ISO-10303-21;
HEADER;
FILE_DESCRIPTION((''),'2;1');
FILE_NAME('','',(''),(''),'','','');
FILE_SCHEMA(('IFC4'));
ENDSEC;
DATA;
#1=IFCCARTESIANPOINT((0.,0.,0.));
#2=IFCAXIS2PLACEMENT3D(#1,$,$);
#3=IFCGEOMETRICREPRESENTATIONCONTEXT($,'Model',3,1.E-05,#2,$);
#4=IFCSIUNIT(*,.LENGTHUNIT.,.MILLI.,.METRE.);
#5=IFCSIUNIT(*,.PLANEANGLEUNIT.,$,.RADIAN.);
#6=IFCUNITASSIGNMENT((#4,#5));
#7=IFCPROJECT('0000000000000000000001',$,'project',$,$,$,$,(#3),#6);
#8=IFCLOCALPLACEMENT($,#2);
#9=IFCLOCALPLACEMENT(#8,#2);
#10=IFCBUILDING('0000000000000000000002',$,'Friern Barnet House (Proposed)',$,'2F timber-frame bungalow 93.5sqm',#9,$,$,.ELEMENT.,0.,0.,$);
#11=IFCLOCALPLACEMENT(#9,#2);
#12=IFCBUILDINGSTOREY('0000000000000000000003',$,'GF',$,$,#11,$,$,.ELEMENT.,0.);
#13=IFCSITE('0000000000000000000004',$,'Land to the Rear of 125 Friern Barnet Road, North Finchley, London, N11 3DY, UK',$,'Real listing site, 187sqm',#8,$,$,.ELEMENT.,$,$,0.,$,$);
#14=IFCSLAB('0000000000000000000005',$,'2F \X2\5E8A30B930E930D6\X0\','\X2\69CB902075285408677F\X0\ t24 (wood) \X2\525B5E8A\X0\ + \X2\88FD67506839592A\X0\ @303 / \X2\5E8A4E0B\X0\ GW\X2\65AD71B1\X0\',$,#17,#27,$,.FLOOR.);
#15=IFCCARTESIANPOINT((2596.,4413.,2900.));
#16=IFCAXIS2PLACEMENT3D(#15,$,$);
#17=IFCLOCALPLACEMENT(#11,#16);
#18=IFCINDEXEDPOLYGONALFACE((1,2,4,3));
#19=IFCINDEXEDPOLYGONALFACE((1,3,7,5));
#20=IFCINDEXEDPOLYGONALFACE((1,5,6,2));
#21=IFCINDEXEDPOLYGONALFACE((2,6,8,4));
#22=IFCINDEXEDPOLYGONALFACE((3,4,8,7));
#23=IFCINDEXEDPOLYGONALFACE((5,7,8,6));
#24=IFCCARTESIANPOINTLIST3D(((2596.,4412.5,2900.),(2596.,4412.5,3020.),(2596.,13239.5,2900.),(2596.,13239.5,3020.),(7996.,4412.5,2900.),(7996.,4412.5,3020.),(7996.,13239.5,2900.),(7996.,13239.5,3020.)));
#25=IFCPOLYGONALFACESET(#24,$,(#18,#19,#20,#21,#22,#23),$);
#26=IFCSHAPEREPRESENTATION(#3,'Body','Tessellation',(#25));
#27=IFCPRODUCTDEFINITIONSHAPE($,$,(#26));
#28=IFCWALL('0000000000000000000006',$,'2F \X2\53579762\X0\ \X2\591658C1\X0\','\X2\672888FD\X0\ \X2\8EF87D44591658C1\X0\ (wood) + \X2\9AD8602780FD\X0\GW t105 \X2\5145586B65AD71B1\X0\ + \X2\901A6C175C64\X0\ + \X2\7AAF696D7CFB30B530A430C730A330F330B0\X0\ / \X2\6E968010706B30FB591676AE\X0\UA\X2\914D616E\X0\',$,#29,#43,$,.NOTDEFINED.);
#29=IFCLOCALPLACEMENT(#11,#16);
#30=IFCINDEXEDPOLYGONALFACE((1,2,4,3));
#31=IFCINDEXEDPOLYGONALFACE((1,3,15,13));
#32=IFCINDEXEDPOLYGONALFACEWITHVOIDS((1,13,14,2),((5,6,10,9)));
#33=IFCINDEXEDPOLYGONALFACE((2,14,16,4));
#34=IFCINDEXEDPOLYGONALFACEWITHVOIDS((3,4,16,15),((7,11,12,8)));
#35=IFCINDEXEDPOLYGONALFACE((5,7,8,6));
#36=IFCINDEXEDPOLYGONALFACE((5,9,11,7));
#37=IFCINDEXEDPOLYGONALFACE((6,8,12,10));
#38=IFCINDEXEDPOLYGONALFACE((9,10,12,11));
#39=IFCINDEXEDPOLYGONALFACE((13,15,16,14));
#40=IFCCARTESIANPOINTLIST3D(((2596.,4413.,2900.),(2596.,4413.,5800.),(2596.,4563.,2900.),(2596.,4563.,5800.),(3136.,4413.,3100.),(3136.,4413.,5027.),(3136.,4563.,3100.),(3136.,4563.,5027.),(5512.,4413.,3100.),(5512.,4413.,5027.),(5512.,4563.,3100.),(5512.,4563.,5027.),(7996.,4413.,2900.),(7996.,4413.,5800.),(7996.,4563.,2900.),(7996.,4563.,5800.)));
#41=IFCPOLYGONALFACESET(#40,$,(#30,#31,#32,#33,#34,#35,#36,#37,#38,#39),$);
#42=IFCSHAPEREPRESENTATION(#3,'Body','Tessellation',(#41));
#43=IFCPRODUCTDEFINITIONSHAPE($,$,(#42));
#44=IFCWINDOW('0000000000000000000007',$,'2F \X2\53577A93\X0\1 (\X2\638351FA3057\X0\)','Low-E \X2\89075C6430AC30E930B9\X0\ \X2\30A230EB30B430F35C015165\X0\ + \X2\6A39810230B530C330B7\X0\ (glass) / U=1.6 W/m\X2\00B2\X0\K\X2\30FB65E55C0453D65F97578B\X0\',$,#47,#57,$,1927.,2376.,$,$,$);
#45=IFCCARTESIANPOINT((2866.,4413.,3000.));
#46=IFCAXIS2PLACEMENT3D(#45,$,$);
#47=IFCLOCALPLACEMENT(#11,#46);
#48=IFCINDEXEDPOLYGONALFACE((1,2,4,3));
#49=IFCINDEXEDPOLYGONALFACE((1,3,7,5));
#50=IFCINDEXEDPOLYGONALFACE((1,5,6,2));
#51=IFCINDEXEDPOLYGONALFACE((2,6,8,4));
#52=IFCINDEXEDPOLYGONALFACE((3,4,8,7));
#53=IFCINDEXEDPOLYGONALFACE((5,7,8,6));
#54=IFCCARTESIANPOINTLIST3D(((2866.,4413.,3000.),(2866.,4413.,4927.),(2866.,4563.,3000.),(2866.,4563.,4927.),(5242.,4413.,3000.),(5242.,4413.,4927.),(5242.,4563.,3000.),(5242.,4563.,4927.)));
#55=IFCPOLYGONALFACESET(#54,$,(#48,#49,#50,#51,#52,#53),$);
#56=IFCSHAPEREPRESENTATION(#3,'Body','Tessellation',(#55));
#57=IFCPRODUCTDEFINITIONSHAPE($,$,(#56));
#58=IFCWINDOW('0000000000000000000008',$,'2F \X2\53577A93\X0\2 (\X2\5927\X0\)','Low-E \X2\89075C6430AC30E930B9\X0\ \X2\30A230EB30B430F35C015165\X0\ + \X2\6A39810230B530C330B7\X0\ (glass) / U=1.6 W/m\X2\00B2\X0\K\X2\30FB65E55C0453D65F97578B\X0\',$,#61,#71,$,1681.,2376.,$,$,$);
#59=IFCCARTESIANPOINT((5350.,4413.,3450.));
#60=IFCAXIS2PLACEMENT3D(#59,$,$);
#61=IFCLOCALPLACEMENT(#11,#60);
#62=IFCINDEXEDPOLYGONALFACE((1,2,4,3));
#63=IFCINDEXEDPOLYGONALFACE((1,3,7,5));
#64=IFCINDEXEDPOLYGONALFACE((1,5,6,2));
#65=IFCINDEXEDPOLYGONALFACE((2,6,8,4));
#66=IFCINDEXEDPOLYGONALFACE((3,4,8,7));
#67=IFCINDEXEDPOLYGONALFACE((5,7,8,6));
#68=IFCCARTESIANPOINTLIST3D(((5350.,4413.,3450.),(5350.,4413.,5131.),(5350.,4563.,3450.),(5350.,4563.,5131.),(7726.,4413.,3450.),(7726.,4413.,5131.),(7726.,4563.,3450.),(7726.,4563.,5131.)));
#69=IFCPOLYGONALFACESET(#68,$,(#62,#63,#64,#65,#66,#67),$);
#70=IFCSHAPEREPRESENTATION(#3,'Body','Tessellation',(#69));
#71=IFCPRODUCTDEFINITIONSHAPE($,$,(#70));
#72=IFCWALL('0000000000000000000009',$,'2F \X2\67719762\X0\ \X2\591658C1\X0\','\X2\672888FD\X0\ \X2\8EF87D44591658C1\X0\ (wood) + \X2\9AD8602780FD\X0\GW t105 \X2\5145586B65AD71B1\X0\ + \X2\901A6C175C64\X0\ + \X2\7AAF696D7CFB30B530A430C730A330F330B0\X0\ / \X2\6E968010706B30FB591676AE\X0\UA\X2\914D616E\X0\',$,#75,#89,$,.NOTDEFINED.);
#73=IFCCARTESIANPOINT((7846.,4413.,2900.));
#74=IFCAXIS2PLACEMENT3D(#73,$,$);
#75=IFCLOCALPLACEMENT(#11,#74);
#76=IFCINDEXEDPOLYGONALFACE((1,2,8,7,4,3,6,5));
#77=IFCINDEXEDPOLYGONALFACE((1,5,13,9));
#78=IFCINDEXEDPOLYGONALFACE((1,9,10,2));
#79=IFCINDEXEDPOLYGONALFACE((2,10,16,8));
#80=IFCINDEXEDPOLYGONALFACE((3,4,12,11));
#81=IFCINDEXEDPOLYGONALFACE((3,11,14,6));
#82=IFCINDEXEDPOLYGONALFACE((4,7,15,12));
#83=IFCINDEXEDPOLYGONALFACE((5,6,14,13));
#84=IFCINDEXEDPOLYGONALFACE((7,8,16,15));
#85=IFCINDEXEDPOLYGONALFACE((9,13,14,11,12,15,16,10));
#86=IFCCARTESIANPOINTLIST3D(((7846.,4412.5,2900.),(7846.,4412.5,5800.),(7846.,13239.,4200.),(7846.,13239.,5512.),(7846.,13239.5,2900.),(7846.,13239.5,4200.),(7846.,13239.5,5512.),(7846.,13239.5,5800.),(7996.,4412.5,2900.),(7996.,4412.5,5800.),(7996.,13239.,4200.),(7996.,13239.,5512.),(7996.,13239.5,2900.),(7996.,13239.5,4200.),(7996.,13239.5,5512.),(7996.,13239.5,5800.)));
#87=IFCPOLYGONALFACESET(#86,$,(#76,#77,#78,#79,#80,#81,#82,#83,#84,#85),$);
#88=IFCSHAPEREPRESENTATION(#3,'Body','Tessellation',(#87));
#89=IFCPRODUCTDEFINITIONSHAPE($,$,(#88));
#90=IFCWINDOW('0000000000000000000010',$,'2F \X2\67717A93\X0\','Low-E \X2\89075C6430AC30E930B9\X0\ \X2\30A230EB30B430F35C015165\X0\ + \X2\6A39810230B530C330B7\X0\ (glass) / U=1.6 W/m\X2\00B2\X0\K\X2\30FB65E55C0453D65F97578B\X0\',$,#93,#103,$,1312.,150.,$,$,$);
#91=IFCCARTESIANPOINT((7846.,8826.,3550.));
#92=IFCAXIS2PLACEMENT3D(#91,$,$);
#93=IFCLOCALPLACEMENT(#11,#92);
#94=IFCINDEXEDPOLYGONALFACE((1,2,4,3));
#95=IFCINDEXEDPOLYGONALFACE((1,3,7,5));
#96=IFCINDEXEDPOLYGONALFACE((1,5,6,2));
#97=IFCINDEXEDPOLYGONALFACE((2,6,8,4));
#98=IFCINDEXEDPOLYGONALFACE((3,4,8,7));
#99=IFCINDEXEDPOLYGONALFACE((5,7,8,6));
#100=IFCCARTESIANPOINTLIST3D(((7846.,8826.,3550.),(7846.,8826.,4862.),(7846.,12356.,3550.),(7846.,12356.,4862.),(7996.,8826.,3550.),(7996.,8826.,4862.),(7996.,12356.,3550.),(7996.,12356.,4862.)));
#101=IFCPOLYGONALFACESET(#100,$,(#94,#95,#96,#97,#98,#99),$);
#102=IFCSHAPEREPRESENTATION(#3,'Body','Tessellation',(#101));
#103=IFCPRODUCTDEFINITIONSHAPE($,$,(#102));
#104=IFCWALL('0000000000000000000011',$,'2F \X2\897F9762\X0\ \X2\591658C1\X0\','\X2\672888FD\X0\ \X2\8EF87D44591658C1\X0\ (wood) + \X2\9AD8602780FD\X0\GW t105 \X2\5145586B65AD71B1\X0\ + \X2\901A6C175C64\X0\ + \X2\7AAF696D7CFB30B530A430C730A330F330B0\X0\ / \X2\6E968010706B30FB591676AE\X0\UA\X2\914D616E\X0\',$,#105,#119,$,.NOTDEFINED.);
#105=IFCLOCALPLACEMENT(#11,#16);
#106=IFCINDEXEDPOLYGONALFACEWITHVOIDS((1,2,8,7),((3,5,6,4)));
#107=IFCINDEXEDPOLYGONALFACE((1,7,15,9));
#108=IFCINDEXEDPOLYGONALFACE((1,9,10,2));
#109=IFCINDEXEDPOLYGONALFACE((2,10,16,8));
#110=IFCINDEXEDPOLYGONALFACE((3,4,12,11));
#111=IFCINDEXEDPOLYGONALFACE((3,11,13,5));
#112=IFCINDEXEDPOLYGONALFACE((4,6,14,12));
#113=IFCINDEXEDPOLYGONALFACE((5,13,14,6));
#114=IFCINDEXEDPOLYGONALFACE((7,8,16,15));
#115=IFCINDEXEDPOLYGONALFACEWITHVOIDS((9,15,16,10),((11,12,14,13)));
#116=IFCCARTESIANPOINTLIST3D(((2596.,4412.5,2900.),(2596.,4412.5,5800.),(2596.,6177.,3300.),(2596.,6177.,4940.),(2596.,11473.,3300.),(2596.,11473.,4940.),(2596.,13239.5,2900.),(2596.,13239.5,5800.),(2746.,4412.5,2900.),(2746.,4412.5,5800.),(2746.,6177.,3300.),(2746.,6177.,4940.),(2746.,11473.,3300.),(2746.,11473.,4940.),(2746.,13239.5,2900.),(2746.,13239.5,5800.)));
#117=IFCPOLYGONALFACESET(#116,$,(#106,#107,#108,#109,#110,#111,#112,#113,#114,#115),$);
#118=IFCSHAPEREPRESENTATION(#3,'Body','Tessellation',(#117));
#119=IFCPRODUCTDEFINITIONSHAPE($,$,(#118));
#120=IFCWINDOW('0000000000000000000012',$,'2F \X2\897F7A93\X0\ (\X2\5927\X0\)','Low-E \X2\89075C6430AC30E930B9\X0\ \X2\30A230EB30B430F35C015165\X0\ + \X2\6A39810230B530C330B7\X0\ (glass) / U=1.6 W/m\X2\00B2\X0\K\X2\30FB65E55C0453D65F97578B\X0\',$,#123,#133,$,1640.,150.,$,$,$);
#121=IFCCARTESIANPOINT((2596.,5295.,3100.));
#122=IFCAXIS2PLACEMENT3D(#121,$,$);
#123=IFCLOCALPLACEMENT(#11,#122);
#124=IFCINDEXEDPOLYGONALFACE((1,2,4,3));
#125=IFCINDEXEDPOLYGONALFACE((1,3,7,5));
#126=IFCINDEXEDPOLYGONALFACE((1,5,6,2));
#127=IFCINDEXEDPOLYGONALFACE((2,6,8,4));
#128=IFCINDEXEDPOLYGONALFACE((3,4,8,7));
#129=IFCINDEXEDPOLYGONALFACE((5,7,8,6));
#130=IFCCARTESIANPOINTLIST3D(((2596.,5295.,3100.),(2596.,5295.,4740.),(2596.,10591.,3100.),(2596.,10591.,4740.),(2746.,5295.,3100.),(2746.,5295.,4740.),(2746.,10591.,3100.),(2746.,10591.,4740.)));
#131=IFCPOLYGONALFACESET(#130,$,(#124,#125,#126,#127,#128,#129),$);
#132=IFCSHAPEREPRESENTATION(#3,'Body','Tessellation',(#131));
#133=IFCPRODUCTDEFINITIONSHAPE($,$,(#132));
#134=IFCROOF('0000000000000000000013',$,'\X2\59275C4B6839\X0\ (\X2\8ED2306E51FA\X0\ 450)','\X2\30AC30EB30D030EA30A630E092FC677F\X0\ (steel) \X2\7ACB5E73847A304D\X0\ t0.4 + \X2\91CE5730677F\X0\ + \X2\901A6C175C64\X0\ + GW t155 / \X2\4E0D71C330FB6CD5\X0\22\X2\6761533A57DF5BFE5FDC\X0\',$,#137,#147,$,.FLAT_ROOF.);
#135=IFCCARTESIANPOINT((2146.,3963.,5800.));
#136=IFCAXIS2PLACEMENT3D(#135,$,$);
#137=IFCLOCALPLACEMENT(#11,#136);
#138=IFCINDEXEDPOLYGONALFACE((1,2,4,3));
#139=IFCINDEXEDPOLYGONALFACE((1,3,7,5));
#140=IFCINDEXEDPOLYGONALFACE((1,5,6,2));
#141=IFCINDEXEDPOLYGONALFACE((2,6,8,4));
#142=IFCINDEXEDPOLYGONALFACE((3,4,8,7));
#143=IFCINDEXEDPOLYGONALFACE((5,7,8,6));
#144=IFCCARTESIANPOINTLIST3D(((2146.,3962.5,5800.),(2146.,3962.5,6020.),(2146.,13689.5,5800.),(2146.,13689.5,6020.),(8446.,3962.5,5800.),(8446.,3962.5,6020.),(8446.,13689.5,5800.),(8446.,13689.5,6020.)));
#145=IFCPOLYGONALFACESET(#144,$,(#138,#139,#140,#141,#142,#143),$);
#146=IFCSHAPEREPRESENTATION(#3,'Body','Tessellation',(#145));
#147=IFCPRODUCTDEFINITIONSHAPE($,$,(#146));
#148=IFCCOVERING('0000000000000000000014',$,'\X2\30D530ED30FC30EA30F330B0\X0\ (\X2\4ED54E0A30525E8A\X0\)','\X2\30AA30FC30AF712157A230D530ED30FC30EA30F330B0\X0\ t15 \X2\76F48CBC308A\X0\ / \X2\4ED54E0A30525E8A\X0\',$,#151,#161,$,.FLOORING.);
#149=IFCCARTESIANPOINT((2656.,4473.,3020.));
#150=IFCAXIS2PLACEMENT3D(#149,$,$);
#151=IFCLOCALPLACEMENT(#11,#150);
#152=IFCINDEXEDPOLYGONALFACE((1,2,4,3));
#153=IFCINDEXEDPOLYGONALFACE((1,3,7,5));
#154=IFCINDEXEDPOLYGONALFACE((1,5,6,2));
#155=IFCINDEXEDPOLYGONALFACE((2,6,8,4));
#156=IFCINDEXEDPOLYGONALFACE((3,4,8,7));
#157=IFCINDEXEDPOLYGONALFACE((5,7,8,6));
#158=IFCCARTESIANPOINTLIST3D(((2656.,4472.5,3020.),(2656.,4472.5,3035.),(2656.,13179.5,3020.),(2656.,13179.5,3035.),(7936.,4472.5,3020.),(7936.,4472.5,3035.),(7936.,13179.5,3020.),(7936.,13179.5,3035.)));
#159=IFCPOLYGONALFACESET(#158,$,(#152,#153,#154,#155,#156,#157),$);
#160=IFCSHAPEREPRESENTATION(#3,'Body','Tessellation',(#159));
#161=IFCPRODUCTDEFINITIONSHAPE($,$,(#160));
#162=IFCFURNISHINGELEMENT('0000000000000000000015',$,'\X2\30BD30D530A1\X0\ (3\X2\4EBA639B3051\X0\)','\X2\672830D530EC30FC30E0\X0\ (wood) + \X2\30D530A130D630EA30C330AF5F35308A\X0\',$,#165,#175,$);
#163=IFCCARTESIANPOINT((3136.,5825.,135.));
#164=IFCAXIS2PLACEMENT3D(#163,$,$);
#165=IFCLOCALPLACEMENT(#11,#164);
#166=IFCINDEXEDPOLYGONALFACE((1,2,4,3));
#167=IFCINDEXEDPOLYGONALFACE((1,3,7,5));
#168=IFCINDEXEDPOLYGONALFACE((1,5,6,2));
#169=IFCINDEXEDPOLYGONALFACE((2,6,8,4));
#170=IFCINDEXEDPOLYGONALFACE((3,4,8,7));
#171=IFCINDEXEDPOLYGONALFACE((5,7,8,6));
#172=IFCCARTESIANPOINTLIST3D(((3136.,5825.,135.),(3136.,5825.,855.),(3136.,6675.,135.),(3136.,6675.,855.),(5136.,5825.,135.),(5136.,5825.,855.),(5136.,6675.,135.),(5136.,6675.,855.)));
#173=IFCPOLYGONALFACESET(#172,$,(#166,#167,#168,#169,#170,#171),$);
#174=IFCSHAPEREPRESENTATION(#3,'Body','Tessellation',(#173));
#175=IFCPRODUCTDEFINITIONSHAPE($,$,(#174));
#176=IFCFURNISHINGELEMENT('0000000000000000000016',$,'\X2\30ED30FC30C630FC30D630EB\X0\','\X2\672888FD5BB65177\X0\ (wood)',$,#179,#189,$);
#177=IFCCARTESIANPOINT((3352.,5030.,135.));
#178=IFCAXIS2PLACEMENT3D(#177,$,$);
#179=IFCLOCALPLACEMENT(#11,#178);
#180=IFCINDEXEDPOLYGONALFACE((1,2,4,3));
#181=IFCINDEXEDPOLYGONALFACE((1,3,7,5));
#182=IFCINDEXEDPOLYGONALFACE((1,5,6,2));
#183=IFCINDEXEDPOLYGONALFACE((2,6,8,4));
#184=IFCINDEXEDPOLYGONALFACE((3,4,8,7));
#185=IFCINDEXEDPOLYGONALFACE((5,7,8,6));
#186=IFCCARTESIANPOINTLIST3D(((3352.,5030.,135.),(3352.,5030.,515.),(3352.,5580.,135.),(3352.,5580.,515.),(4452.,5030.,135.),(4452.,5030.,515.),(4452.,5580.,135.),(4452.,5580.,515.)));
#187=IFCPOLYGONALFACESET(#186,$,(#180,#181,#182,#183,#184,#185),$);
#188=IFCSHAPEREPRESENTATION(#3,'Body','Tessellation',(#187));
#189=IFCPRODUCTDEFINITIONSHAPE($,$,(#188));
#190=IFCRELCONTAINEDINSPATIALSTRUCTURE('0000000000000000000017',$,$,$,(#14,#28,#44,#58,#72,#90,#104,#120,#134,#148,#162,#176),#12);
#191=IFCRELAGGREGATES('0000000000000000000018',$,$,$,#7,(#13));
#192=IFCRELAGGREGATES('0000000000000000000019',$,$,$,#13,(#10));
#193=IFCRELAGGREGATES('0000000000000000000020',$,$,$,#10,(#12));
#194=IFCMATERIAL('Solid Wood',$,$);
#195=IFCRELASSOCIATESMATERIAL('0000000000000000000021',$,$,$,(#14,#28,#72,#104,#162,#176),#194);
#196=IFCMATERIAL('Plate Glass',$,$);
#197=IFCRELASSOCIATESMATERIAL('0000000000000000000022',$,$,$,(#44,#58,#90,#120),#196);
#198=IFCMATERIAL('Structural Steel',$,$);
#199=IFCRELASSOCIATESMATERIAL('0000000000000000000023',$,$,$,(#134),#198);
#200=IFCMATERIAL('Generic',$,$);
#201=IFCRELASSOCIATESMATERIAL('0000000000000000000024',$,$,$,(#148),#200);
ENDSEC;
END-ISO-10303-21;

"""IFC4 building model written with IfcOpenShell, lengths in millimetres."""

from ifc_helpers import new_model, si_unit, frame, frame_2d, origin, place, context, project, spatial, rectangle, extrude, material, element, fill, save


model = new_model("IFC4")

# Units and contexts
model_context = context("Model", 3, precision=1e-05, world=origin())
ifc_project = project(units=[si_unit("LENGTHUNIT", "METRE", prefix="MILLI"), si_unit("PLANEANGLEUNIT", "RADIAN")], contexts=[model_context])

# Site, building, storey
site_placement = place(None, origin())
site = spatial("IfcSite", under=ifc_project, at=site_placement, Name="Land to the Rear of 125 Friern Barnet Road, North Finchley, London, N11 3DY, UK", ObjectType="Real listing site, 187sqm", CompositionType="ELEMENT", RefElevation=0.0)
building_placement = place(site_placement, origin())
building = spatial("IfcBuilding", under=site, at=building_placement, Name="Friern Barnet House (Proposed)", ObjectType="2F timber-frame bungalow 93.5sqm", CompositionType="ELEMENT", ElevationOfRefHeight=0.0, ElevationOfTerrain=0.0)
storey_placement = place(building_placement, origin())
storey = spatial("IfcBuildingStorey", under=building, at=storey_placement, Name="GF", CompositionType="ELEMENT", Elevation=0.0)

# Slab
ifc_material_1 = material(Name="Solid Wood")
slab_placement = place(storey_placement, frame((2596.0, 4413.0, 2900.0)))
element("IfcSlab", 1, at=slab_placement, inside=storey, material=ifc_material_1, Name="2F 床スラブ", Description="構造用合板 t24 (wood) 剛床 + 製材根太 @303 / 床下 GW断熱", PredefinedType="FLOOR", context=model_context, shape_type="SweptSolid", body=[
    extrude(rectangle(XDim=5400.0, YDim=8827.0, at=frame_2d((2700.0, 4413.0))), frame((2596.0, 4413.0, 2900.0)), (0.0, 0.0, 1.0), 120.0),
])

# Wall, openings, windows
wall_1_placement = place(storey_placement, frame((2596.0, 4413.0, 2900.0)))
wall_1 = element("IfcWall", 2, at=wall_1_placement, inside=storey, material=ifc_material_1, Name="2F 南面 外壁", Description="木製 軸組外壁 (wood) + 高性能GW t105 充填断熱 + 通気層 + 窯業系サイディング / 準耐火・外皮UA配慮", PredefinedType="NOTDEFINED", context=model_context, shape_type="SweptSolid", body=[
    extrude(rectangle(XDim=5400.0, YDim=150.0, at=frame_2d((2700.0, 75.0))), frame((2596.0, 4413.0, 2900.0)), (0.0, 0.0, 1.0), 2900.0),
])
opening_1_placement = place(storey_placement, frame((2866.0, 4413.0, 3000.0)))
opening_1 = element("IfcOpeningElement", 3, at=opening_1_placement, cuts=wall_1, PredefinedType="NOTDEFINED", context=model_context, shape_type="SweptSolid", body=[
    extrude(rectangle(XDim=2376.0, YDim=150.0, at=frame_2d((1188.0, 75.0))), frame((2866.0, 4413.0, 3000.0)), (0.0, 0.0, 1.0), 1927.0),
])
opening_2_placement = place(storey_placement, frame((5350.0, 4413.0, 3450.0)))
opening_2 = element("IfcOpeningElement", 4, at=opening_2_placement, cuts=wall_1, PredefinedType="NOTDEFINED", context=model_context, shape_type="SweptSolid", body=[
    extrude(rectangle(XDim=2376.0, YDim=150.0, at=frame_2d((1188.0, 75.0))), frame((5350.0, 4413.0, 3450.0)), (0.0, 0.0, 1.0), 1681.0),
])
ifc_material_2 = material(Name="Plate Glass")
window_1_placement = place(storey_placement, frame((2866.0, 4413.0, 3000.0)))
window_1 = element("IfcWindow", 5, at=window_1_placement, inside=storey, material=ifc_material_2, Name="2F 南窓1 (掃出し)", Description="Low-E 複層ガラス アルゴン封入 + 樹脂サッシ (glass) / U=1.6 W/m²K・日射取得型", OverallHeight=1927.0, OverallWidth=2376.0, context=model_context, shape_type="SweptSolid", body=[
    extrude(rectangle(XDim=2376.0, YDim=150.0, at=frame_2d((1188.0, 75.0))), frame((2866.0, 4413.0, 3000.0)), (0.0, 0.0, 1.0), 1927.0),
])
fill(opening_1, window_1)
window_2_placement = place(storey_placement, frame((5350.0, 4413.0, 3450.0)))
window_2 = element("IfcWindow", 6, at=window_2_placement, inside=storey, material=ifc_material_2, Name="2F 南窓2 (大)", Description="Low-E 複層ガラス アルゴン封入 + 樹脂サッシ (glass) / U=1.6 W/m²K・日射取得型", OverallHeight=1681.0, OverallWidth=2376.0, context=model_context, shape_type="SweptSolid", body=[
    extrude(rectangle(XDim=2376.0, YDim=150.0, at=frame_2d((1188.0, 75.0))), frame((5350.0, 4413.0, 3450.0)), (0.0, 0.0, 1.0), 1681.0),
])
fill(opening_2, window_2)

# Walls, openings, windows
wall_2_placement = place(storey_placement, frame((7846.0, 4413.0, 2900.0)))
wall_2 = element("IfcWall", 7, at=wall_2_placement, inside=storey, material=ifc_material_1, Name="2F 東面 外壁", Description="木製 軸組外壁 (wood) + 高性能GW t105 充填断熱 + 通気層 + 窯業系サイディング / 準耐火・外皮UA配慮", PredefinedType="NOTDEFINED", context=model_context, shape_type="SweptSolid", body=[
    extrude(rectangle(XDim=150.0, YDim=8827.0, at=frame_2d((75.0, 4413.0))), frame((7846.0, 4413.0, 2900.0)), (0.0, 0.0, 1.0), 2900.0),
])
opening_3_placement = place(storey_placement, frame((7846.0, 8826.0, 3550.0)))
opening_3 = element("IfcOpeningElement", 8, at=opening_3_placement, cuts=wall_2, PredefinedType="NOTDEFINED", context=model_context, shape_type="SweptSolid", body=[
    extrude(rectangle(XDim=150.0, YDim=3530.0, at=frame_2d((75.0, 1765.0))), frame((7846.0, 8826.0, 3550.0)), (0.0, 0.0, 1.0), 1312.0),
])
window_3_placement = place(storey_placement, frame((7846.0, 8826.0, 3550.0)))
window_3 = element("IfcWindow", 9, at=window_3_placement, inside=storey, material=ifc_material_2, Name="2F 東窓", Description="Low-E 複層ガラス アルゴン封入 + 樹脂サッシ (glass) / U=1.6 W/m²K・日射取得型", OverallHeight=1312.0, OverallWidth=150.0, context=model_context, shape_type="SweptSolid", body=[
    extrude(rectangle(XDim=150.0, YDim=3530.0, at=frame_2d((75.0, 1765.0))), frame((7846.0, 8826.0, 3550.0)), (0.0, 0.0, 1.0), 1312.0),
])
fill(opening_3, window_3)
wall_3_placement = place(storey_placement, frame((2596.0, 4413.0, 2900.0)))
wall_3 = element("IfcWall", 10, at=wall_3_placement, inside=storey, material=ifc_material_1, Name="2F 西面 外壁", Description="木製 軸組外壁 (wood) + 高性能GW t105 充填断熱 + 通気層 + 窯業系サイディング / 準耐火・外皮UA配慮", PredefinedType="NOTDEFINED", context=model_context, shape_type="SweptSolid", body=[
    extrude(rectangle(XDim=150.0, YDim=8827.0, at=frame_2d((75.0, 4413.0))), frame((2596.0, 4413.0, 2900.0)), (0.0, 0.0, 1.0), 2900.0),
])
opening_4_placement = place(storey_placement, frame((2596.0, 5295.0, 3100.0)))
opening_4 = element("IfcOpeningElement", 11, at=opening_4_placement, cuts=wall_3, PredefinedType="NOTDEFINED", context=model_context, shape_type="SweptSolid", body=[
    extrude(rectangle(XDim=150.0, YDim=5296.0, at=frame_2d((75.0, 2648.0))), frame((2596.0, 5295.0, 3100.0)), (0.0, 0.0, 1.0), 1640.0),
])
window_4_placement = place(storey_placement, frame((2596.0, 5295.0, 3100.0)))
window_4 = element("IfcWindow", 12, at=window_4_placement, inside=storey, material=ifc_material_2, Name="2F 西窓 (大)", Description="Low-E 複層ガラス アルゴン封入 + 樹脂サッシ (glass) / U=1.6 W/m²K・日射取得型", OverallHeight=1640.0, OverallWidth=150.0, context=model_context, shape_type="SweptSolid", body=[
    extrude(rectangle(XDim=150.0, YDim=5296.0, at=frame_2d((75.0, 2648.0))), frame((2596.0, 5295.0, 3100.0)), (0.0, 0.0, 1.0), 1640.0),
])
fill(opening_4, window_4)

# Roof
ifc_material_3 = material(Name="Structural Steel")
roof_placement = place(storey_placement, frame((2146.0, 3963.0, 5800.0)))
element("IfcRoof", 13, at=roof_placement, inside=storey, material=ifc_material_3, Name="大屋根 (軒の出 450)", Description="ガルバリウム鋼板 (steel) 立平葺き t0.4 + 野地板 + 通気層 + GW t155 / 不燃・法22条区域対応", PredefinedType="FLAT_ROOF", context=model_context, shape_type="SweptSolid", body=[
    extrude(rectangle(XDim=6300.0, YDim=9727.0, at=frame_2d((3150.0, 4863.0))), frame((2146.0, 3963.0, 5800.0)), (0.0, 0.0, 1.0), 220.0),
])

# Covering
ifc_material_4 = material(Name="Generic")
covering_placement = place(storey_placement, frame((2656.0, 4473.0, 3020.0)))
element("IfcCovering", 14, at=covering_placement, inside=storey, material=ifc_material_4, Name="フローリング (仕上げ床)", Description="オーク無垢フローリング t15 直貼り / 仕上げ床", PredefinedType="FLOORING", context=model_context, shape_type="SweptSolid", body=[
    extrude(rectangle(XDim=5280.0, YDim=8707.0, at=frame_2d((2640.0, 4353.0))), frame((2656.0, 4473.0, 3020.0)), (0.0, 0.0, 1.0), 15.0),
])

# Furnishing elements
furnishing_1_placement = place(storey_placement, frame((3136.0, 5825.0, 135.0)))
element("IfcFurnishingElement", 15, at=furnishing_1_placement, inside=storey, material=ifc_material_1, Name="ソファ (3人掛け)", Description="木フレーム (wood) + ファブリック張り", context=model_context, shape_type="SweptSolid", body=[
    extrude(rectangle(XDim=2000.0, YDim=850.0, at=frame_2d((1000.0, 425.0))), frame((3136.0, 5825.0, 135.0)), (0.0, 0.0, 1.0), 720.0),
])
furnishing_2_placement = place(storey_placement, frame((3352.0, 5030.0, 135.0)))
element("IfcFurnishingElement", 16, at=furnishing_2_placement, inside=storey, material=ifc_material_1, Name="ローテーブル", Description="木製家具 (wood)", context=model_context, shape_type="SweptSolid", body=[
    extrude(rectangle(XDim=1100.0, YDim=550.0, at=frame_2d((550.0, 275.0))), frame((3352.0, 5030.0, 135.0)), (0.0, 0.0, 1.0), 380.0),
])

save(model, "model.ifc")
